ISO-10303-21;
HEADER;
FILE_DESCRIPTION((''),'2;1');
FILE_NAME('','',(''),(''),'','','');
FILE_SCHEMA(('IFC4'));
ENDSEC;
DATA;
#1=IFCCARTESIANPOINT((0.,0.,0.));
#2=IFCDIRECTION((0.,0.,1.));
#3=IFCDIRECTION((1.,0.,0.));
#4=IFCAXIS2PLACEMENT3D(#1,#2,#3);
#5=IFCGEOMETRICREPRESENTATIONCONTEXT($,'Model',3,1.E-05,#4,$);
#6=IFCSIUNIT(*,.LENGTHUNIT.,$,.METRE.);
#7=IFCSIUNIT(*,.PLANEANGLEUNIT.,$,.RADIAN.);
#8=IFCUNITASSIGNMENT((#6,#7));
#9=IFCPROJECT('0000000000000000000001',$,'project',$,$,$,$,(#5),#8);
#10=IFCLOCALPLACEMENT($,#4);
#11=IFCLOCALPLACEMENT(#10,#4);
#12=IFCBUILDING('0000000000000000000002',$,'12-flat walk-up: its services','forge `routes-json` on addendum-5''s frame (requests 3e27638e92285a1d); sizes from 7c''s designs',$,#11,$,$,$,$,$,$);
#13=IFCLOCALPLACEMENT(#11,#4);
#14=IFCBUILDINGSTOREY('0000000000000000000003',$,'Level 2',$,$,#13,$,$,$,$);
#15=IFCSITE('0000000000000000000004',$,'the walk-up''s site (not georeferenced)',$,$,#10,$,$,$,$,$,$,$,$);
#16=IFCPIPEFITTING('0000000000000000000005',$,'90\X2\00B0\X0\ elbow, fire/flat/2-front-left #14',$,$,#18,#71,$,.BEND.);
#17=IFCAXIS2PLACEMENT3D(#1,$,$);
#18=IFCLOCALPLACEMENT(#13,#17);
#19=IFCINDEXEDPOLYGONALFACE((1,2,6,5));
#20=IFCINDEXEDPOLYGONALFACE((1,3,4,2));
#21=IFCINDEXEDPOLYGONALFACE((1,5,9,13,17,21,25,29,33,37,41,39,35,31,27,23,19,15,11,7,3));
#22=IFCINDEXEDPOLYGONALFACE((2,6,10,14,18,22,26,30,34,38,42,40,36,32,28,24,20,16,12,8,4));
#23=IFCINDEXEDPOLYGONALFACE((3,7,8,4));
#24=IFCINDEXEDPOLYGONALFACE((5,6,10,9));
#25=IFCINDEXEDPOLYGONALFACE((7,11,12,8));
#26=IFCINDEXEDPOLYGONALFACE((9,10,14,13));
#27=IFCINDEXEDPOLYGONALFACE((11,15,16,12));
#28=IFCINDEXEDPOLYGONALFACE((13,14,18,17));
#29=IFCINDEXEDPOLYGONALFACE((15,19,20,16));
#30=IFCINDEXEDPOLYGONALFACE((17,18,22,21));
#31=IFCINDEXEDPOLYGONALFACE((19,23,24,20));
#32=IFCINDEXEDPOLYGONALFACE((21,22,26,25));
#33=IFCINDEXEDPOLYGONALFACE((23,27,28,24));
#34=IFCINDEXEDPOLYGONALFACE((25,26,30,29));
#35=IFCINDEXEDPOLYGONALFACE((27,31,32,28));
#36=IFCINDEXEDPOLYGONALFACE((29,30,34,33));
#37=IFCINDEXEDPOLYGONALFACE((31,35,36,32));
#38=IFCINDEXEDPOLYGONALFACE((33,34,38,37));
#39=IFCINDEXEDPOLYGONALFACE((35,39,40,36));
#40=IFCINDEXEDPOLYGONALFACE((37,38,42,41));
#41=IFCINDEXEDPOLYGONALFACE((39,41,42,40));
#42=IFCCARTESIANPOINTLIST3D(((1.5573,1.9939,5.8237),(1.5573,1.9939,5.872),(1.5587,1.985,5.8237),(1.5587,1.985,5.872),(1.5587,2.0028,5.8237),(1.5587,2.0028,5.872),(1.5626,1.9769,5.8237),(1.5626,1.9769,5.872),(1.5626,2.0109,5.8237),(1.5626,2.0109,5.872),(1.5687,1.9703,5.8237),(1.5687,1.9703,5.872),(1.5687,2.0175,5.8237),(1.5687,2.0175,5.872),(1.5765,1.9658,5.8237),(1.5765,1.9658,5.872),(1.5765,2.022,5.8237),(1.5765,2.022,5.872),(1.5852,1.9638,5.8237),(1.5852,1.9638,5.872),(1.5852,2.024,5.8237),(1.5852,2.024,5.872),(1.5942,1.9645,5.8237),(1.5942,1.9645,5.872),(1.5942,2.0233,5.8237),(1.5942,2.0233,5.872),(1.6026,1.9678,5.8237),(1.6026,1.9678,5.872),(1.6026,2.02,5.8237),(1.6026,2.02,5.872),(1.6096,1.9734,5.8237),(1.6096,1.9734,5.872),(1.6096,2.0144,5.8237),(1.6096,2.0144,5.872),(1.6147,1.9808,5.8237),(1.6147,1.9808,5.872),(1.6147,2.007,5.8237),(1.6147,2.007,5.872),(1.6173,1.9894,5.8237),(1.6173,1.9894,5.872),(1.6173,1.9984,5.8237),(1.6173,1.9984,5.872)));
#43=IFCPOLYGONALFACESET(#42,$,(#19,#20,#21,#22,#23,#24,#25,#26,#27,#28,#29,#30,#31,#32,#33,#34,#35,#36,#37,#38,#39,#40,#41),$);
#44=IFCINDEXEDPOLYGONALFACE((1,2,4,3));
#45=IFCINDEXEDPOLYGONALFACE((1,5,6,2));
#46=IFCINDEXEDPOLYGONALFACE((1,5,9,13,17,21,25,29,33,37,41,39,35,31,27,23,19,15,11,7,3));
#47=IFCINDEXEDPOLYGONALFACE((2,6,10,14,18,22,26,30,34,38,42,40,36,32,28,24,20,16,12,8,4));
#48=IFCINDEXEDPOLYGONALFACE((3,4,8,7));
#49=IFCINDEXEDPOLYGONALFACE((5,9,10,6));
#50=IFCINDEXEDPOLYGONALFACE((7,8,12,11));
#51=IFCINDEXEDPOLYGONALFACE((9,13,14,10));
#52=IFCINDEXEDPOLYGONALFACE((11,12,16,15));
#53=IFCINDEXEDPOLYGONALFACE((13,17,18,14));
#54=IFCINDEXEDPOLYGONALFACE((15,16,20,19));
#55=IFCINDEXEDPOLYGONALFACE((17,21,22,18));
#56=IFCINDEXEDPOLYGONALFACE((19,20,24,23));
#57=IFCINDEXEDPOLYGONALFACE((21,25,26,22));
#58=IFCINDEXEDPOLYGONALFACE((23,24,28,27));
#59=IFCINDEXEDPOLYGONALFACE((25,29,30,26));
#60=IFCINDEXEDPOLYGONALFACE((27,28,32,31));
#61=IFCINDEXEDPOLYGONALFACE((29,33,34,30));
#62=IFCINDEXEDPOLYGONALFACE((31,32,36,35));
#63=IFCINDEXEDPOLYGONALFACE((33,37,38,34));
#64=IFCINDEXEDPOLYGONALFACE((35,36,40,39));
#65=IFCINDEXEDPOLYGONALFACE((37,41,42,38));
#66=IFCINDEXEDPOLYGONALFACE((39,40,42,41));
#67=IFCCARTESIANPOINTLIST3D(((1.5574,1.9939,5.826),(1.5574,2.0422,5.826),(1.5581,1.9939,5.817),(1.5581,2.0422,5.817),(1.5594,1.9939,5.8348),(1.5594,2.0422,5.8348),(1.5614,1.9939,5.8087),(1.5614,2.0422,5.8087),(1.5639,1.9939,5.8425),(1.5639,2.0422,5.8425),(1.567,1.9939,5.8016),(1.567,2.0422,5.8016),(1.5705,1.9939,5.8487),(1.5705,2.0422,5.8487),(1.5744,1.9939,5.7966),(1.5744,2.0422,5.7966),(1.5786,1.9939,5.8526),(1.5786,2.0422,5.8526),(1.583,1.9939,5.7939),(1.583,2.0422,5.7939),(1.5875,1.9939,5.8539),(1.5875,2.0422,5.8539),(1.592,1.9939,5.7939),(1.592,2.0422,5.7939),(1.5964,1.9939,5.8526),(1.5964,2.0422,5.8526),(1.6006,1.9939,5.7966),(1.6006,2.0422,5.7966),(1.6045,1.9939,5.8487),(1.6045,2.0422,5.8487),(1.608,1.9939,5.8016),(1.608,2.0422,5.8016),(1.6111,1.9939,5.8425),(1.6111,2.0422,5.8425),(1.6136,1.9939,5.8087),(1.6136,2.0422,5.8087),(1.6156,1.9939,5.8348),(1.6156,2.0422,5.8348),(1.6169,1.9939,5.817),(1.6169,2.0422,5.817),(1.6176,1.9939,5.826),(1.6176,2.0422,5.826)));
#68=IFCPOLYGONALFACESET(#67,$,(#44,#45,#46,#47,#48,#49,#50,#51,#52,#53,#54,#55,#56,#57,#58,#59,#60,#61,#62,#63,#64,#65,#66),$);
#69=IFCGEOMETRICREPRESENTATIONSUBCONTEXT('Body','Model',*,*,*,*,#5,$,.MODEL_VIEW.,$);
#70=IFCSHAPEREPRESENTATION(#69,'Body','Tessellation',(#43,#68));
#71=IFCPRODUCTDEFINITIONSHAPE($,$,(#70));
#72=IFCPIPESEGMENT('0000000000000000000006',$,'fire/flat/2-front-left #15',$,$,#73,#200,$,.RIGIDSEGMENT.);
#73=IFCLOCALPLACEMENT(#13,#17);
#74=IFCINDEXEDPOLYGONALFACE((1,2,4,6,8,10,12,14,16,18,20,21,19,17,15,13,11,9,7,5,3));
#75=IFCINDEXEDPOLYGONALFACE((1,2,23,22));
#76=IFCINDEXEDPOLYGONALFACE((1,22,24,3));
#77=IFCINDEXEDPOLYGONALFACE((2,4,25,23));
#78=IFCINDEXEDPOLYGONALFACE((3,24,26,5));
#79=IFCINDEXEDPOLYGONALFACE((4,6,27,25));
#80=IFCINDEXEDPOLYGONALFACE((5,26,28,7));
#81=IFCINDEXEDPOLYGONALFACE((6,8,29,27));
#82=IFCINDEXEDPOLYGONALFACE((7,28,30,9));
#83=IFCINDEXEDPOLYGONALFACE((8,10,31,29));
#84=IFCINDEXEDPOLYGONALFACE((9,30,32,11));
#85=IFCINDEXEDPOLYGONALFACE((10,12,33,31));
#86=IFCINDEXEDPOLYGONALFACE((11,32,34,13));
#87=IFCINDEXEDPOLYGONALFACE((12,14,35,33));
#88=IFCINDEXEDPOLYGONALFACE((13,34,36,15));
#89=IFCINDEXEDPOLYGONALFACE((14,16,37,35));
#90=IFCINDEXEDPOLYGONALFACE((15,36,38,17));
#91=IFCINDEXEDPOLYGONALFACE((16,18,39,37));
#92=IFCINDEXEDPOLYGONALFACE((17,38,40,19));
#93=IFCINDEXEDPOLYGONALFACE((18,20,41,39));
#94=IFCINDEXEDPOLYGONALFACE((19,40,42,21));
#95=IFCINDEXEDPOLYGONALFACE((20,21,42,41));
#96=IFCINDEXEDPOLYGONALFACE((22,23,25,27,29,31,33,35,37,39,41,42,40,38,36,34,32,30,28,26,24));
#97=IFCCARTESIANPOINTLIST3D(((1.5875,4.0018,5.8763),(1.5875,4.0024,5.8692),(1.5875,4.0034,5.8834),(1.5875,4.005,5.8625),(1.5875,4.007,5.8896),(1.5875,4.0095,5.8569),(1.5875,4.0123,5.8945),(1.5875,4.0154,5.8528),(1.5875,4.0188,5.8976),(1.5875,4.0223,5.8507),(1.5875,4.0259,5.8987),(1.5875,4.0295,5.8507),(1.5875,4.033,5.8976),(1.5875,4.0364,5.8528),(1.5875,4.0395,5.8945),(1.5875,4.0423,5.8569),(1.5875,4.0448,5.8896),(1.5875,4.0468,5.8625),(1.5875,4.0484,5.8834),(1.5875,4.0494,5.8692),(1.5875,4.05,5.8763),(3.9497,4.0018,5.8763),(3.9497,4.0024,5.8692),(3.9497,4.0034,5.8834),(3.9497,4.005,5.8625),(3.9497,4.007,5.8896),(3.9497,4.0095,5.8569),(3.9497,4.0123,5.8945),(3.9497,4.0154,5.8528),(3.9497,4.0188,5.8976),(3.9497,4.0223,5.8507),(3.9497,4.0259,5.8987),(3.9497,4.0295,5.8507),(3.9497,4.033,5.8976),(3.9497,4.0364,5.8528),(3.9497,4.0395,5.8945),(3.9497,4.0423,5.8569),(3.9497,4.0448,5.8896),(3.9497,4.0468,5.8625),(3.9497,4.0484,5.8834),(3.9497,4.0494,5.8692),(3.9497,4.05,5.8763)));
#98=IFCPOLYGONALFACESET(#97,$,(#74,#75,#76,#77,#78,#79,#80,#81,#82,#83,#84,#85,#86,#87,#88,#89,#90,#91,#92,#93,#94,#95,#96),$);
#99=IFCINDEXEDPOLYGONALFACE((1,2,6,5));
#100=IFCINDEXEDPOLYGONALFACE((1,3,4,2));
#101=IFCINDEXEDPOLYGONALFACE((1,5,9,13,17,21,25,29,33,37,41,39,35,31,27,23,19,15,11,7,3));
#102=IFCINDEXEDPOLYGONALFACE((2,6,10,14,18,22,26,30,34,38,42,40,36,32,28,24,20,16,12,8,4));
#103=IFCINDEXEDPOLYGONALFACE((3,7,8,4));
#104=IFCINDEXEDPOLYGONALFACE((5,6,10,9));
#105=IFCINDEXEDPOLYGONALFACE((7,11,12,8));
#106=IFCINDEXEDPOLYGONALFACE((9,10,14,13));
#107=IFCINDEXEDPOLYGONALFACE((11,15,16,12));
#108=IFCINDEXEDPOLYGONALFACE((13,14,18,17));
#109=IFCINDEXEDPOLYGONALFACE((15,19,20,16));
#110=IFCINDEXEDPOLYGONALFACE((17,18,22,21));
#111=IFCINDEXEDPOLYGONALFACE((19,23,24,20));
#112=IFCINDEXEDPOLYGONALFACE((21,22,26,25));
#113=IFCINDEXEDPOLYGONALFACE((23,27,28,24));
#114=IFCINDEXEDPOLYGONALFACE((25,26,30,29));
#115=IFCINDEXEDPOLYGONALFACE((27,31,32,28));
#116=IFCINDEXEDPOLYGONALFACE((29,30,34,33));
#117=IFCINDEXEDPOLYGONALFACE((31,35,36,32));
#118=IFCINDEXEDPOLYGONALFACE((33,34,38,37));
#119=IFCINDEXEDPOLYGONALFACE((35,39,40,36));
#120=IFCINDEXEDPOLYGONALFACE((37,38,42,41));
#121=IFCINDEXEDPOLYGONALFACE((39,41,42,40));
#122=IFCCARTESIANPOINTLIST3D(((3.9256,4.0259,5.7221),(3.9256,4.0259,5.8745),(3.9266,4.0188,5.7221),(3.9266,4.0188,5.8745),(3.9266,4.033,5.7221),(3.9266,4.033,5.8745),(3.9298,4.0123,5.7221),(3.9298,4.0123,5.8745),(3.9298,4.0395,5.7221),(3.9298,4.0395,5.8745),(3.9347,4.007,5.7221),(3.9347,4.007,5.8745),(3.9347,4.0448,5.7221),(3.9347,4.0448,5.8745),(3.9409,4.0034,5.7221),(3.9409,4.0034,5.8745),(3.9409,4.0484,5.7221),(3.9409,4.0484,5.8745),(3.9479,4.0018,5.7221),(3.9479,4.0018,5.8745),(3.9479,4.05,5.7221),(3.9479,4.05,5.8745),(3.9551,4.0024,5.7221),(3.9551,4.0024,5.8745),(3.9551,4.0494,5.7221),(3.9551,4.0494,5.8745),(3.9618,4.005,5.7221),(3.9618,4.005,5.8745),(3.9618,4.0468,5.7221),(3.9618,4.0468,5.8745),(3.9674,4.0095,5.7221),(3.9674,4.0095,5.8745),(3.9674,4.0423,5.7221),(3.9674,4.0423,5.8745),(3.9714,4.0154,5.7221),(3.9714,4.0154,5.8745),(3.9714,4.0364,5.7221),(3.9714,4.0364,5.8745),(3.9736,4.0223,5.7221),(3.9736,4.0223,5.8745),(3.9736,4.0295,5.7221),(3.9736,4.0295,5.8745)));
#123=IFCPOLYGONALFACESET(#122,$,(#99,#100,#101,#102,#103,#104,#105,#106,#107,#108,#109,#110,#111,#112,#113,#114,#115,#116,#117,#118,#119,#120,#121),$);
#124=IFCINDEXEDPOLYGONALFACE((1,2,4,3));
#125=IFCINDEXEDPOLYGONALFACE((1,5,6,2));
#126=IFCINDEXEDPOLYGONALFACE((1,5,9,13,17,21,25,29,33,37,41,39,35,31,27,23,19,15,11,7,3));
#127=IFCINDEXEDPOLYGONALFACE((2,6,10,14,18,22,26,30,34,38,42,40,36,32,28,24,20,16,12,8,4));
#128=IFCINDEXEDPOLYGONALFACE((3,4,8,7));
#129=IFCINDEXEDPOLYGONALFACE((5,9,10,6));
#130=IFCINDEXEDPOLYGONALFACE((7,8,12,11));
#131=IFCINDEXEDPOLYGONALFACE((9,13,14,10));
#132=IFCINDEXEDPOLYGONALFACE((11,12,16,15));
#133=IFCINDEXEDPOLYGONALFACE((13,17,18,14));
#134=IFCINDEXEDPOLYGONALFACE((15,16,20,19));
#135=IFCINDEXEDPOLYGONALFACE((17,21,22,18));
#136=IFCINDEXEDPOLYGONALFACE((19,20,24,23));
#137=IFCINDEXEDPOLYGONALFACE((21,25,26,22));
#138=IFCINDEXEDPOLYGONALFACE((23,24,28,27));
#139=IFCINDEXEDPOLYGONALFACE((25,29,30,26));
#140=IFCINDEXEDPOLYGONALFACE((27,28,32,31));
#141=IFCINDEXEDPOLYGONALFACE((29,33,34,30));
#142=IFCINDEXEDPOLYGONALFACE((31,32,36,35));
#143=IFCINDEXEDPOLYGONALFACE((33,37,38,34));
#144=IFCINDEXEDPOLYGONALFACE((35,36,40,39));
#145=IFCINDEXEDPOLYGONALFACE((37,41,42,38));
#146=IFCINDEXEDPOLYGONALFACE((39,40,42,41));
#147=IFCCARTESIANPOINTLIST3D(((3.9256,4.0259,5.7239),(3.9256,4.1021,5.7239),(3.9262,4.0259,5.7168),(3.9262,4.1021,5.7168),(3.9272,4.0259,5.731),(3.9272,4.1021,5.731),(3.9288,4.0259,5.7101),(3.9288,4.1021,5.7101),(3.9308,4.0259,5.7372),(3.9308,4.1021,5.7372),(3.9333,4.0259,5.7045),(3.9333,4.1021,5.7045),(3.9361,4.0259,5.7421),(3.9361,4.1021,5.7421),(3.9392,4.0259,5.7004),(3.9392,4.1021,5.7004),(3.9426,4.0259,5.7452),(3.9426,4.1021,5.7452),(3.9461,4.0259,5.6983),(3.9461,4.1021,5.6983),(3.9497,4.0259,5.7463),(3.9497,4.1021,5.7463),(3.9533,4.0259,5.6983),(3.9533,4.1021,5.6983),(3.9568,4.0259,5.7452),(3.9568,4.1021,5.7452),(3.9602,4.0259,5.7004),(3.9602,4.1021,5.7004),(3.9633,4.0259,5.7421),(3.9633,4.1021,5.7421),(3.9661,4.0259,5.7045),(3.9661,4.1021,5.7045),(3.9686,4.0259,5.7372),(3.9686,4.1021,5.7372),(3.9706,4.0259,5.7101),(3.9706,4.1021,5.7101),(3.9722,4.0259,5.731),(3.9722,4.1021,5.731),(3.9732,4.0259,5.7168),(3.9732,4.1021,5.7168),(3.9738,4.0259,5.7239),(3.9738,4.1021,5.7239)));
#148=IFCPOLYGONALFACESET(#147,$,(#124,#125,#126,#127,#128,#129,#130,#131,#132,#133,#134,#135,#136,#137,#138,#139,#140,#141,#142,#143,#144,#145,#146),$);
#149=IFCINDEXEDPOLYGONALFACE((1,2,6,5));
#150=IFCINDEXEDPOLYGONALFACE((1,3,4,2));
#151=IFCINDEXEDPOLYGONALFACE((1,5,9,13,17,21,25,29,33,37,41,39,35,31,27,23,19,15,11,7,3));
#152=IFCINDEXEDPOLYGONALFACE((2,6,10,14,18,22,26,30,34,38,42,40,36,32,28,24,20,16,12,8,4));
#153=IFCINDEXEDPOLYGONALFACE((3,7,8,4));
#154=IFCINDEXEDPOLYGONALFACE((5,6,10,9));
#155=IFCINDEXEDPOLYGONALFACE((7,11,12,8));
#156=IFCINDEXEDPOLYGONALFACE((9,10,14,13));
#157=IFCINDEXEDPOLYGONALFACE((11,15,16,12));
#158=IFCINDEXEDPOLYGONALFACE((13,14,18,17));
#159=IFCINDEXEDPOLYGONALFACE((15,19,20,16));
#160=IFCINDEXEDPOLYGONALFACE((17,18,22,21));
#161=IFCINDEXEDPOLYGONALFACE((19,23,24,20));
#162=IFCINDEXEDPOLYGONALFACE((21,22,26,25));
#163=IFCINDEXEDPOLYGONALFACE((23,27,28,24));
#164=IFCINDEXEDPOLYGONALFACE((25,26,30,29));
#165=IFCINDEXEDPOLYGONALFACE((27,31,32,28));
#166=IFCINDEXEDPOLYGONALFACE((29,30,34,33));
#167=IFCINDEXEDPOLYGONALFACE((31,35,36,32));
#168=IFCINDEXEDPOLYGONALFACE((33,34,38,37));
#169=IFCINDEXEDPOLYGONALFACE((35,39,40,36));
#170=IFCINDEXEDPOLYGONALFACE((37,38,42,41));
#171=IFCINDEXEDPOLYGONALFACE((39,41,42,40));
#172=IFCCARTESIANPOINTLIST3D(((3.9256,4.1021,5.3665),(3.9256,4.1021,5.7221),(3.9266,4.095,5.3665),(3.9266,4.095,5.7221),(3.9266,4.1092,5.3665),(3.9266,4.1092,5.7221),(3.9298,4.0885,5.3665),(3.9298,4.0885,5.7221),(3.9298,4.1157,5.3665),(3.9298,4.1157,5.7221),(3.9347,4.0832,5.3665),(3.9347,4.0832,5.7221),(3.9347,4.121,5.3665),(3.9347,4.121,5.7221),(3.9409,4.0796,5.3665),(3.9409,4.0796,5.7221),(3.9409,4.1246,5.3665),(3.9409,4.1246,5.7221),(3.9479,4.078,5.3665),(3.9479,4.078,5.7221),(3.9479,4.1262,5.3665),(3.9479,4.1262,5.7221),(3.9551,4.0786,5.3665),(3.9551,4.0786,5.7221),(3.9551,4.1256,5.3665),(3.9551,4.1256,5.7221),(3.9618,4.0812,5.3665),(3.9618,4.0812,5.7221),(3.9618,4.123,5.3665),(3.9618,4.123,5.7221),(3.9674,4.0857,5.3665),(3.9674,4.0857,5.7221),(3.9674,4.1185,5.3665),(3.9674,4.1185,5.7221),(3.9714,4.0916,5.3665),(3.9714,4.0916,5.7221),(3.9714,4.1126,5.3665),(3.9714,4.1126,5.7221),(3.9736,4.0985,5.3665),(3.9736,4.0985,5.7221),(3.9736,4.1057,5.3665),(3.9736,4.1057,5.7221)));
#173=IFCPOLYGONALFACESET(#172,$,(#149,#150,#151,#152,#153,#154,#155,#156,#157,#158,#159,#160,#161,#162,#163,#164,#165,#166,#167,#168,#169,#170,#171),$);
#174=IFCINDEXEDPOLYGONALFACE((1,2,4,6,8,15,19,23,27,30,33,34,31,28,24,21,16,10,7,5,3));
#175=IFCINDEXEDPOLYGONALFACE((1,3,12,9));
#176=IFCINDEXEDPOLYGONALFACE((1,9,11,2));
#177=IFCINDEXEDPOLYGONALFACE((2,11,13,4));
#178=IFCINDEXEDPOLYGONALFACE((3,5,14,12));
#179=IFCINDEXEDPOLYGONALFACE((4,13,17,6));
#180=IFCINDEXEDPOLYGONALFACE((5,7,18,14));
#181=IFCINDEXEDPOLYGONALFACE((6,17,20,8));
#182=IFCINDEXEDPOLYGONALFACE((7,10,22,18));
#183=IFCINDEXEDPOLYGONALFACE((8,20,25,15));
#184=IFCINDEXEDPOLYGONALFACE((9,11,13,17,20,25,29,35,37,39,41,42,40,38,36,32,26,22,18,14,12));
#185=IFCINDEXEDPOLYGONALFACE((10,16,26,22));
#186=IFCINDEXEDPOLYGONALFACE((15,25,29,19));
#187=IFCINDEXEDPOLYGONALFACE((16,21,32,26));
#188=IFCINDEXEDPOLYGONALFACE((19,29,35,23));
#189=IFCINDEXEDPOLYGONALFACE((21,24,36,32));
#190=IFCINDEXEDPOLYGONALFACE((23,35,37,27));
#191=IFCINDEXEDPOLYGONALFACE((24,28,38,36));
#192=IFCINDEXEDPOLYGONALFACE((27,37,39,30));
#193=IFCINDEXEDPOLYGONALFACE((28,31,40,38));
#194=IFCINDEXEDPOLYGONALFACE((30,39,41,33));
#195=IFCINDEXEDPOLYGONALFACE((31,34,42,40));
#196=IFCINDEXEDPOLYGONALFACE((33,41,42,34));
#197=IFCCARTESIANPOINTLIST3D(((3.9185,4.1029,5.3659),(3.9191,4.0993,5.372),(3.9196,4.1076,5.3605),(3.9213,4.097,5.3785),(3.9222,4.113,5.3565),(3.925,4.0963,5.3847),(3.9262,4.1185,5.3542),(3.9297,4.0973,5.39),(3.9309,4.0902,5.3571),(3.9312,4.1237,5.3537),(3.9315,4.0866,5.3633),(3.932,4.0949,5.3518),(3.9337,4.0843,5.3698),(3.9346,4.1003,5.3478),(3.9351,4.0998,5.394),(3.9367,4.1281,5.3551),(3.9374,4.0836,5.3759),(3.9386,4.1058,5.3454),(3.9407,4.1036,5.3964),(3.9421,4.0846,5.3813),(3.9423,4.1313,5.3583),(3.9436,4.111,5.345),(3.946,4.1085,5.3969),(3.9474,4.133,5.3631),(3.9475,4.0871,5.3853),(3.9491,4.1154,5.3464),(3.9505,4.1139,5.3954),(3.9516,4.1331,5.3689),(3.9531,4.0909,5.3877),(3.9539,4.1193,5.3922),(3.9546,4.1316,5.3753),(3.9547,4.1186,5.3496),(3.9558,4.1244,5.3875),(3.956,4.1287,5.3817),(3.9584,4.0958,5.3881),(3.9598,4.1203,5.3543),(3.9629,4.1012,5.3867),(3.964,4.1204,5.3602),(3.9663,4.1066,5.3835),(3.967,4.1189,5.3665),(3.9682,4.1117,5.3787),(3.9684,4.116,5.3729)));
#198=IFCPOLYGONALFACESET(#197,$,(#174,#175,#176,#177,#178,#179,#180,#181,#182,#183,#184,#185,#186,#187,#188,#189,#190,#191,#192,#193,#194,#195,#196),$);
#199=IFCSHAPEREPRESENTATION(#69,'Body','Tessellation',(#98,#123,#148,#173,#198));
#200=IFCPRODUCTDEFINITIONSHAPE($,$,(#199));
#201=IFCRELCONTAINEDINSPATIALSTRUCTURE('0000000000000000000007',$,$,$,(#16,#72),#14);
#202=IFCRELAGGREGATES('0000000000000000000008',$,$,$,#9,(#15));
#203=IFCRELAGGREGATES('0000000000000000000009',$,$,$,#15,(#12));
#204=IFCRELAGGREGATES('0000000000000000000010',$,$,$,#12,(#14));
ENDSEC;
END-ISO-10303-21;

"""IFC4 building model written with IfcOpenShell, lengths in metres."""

from ifc_helpers import new_model, entity, si_unit, frame, origin_with_axes, place, context, subcontext, project, spatial, element, save


model = new_model("IFC4")

# Units and contexts
model_context = context("Model", 3, precision=1e-05, world=origin_with_axes())
body_context = subcontext(model_context, "Body", "Model", "MODEL_VIEW")
ifc_project = project(units=[si_unit("LENGTHUNIT", "METRE"), si_unit("PLANEANGLEUNIT", "RADIAN")], contexts=[model_context])

# Site, building, storey
site_placement = place(None, origin_with_axes())
site = spatial("IfcSite", under=ifc_project, at=site_placement, Name="the walk-up's site (not georeferenced)")
building_placement = place(site_placement, origin_with_axes())
building = spatial("IfcBuilding", under=site, at=building_placement, Name="12-flat walk-up: its services", Description="forge `routes-json` on addendum-5's frame (requests 3e27638e92285a1d); sizes from 7c's designs")
storey_placement = place(building_placement, origin_with_axes())
storey = spatial("IfcBuildingStorey", under=building, at=storey_placement, Name="Level 2")

# Pipe fitting
pipe_fitting_1_placement = place(storey_placement, frame((1.5875, 1.9939, 5.872), z_axis=(0.0, 0.0, 1.0), x_axis=(1.0, 0.0, 0.0)))
element("IfcPipeFitting", 1, at=pipe_fitting_1_placement, inside=storey, Name="90° elbow, fire/flat/2-front-left #14", PredefinedType="BEND", context=body_context, shape_type="AdvancedSweptSolid", body=[
    entity("IfcSweptDiskSolid", entity("IfcPolyline", [entity("IfcCartesianPoint", [0.0, 0.0, 0.0]), entity("IfcCartesianPoint", [0.0, 0.0, -0.0483])]), 0.0302),
    entity("IfcSweptDiskSolid", entity("IfcPolyline", [entity("IfcCartesianPoint", [0.0, 0.0, -0.0483]), entity("IfcCartesianPoint", [0.0, 0.0483, -0.0483])]), 0.0302),
])

# Pipe segment
pipe_segment_1_placement = place(storey_placement, frame((1.5875, 4.0259, 5.8745), z_axis=(0.0, 0.0, 1.0), x_axis=(1.0, 0.0, 0.0)))
element("IfcPipeSegment", 2, at=pipe_segment_1_placement, inside=storey, Name="fire/flat/2-front-left #15", PredefinedType="RIGIDSEGMENT", context=body_context, shape_type="AdvancedSweptSolid", body=[
    entity("IfcSweptDiskSolid", entity("IfcPolyline", [entity("IfcCartesianPoint", [0.0, 0.0, 0.0]), entity("IfcCartesianPoint", [2.3622, 0.0, 0.0])]), 0.0241),
    entity("IfcSweptDiskSolid", entity("IfcPolyline", [entity("IfcCartesianPoint", [2.3622, 0.0, 0.0]), entity("IfcCartesianPoint", [2.3622, 0.0, -0.1524])]), 0.0241),
    entity("IfcSweptDiskSolid", entity("IfcPolyline", [entity("IfcCartesianPoint", [2.3622, 0.0, -0.1524]), entity("IfcCartesianPoint", [2.3622, 0.0762, -0.1524])]), 0.0241),
    entity("IfcSweptDiskSolid", entity("IfcPolyline", [entity("IfcCartesianPoint", [2.3622, 0.0762, -0.1524]), entity("IfcCartesianPoint", [2.3622, 0.0762, -0.508])]), 0.0241),
    entity("IfcSweptDiskSolid", entity("IfcPolyline", [entity("IfcCartesianPoint", [2.3622, 0.0762, -0.508]), entity("IfcCartesianPoint", [2.3498, 0.0889, -0.4993])]), 0.0241),
])

save(model, "model.ifc")
